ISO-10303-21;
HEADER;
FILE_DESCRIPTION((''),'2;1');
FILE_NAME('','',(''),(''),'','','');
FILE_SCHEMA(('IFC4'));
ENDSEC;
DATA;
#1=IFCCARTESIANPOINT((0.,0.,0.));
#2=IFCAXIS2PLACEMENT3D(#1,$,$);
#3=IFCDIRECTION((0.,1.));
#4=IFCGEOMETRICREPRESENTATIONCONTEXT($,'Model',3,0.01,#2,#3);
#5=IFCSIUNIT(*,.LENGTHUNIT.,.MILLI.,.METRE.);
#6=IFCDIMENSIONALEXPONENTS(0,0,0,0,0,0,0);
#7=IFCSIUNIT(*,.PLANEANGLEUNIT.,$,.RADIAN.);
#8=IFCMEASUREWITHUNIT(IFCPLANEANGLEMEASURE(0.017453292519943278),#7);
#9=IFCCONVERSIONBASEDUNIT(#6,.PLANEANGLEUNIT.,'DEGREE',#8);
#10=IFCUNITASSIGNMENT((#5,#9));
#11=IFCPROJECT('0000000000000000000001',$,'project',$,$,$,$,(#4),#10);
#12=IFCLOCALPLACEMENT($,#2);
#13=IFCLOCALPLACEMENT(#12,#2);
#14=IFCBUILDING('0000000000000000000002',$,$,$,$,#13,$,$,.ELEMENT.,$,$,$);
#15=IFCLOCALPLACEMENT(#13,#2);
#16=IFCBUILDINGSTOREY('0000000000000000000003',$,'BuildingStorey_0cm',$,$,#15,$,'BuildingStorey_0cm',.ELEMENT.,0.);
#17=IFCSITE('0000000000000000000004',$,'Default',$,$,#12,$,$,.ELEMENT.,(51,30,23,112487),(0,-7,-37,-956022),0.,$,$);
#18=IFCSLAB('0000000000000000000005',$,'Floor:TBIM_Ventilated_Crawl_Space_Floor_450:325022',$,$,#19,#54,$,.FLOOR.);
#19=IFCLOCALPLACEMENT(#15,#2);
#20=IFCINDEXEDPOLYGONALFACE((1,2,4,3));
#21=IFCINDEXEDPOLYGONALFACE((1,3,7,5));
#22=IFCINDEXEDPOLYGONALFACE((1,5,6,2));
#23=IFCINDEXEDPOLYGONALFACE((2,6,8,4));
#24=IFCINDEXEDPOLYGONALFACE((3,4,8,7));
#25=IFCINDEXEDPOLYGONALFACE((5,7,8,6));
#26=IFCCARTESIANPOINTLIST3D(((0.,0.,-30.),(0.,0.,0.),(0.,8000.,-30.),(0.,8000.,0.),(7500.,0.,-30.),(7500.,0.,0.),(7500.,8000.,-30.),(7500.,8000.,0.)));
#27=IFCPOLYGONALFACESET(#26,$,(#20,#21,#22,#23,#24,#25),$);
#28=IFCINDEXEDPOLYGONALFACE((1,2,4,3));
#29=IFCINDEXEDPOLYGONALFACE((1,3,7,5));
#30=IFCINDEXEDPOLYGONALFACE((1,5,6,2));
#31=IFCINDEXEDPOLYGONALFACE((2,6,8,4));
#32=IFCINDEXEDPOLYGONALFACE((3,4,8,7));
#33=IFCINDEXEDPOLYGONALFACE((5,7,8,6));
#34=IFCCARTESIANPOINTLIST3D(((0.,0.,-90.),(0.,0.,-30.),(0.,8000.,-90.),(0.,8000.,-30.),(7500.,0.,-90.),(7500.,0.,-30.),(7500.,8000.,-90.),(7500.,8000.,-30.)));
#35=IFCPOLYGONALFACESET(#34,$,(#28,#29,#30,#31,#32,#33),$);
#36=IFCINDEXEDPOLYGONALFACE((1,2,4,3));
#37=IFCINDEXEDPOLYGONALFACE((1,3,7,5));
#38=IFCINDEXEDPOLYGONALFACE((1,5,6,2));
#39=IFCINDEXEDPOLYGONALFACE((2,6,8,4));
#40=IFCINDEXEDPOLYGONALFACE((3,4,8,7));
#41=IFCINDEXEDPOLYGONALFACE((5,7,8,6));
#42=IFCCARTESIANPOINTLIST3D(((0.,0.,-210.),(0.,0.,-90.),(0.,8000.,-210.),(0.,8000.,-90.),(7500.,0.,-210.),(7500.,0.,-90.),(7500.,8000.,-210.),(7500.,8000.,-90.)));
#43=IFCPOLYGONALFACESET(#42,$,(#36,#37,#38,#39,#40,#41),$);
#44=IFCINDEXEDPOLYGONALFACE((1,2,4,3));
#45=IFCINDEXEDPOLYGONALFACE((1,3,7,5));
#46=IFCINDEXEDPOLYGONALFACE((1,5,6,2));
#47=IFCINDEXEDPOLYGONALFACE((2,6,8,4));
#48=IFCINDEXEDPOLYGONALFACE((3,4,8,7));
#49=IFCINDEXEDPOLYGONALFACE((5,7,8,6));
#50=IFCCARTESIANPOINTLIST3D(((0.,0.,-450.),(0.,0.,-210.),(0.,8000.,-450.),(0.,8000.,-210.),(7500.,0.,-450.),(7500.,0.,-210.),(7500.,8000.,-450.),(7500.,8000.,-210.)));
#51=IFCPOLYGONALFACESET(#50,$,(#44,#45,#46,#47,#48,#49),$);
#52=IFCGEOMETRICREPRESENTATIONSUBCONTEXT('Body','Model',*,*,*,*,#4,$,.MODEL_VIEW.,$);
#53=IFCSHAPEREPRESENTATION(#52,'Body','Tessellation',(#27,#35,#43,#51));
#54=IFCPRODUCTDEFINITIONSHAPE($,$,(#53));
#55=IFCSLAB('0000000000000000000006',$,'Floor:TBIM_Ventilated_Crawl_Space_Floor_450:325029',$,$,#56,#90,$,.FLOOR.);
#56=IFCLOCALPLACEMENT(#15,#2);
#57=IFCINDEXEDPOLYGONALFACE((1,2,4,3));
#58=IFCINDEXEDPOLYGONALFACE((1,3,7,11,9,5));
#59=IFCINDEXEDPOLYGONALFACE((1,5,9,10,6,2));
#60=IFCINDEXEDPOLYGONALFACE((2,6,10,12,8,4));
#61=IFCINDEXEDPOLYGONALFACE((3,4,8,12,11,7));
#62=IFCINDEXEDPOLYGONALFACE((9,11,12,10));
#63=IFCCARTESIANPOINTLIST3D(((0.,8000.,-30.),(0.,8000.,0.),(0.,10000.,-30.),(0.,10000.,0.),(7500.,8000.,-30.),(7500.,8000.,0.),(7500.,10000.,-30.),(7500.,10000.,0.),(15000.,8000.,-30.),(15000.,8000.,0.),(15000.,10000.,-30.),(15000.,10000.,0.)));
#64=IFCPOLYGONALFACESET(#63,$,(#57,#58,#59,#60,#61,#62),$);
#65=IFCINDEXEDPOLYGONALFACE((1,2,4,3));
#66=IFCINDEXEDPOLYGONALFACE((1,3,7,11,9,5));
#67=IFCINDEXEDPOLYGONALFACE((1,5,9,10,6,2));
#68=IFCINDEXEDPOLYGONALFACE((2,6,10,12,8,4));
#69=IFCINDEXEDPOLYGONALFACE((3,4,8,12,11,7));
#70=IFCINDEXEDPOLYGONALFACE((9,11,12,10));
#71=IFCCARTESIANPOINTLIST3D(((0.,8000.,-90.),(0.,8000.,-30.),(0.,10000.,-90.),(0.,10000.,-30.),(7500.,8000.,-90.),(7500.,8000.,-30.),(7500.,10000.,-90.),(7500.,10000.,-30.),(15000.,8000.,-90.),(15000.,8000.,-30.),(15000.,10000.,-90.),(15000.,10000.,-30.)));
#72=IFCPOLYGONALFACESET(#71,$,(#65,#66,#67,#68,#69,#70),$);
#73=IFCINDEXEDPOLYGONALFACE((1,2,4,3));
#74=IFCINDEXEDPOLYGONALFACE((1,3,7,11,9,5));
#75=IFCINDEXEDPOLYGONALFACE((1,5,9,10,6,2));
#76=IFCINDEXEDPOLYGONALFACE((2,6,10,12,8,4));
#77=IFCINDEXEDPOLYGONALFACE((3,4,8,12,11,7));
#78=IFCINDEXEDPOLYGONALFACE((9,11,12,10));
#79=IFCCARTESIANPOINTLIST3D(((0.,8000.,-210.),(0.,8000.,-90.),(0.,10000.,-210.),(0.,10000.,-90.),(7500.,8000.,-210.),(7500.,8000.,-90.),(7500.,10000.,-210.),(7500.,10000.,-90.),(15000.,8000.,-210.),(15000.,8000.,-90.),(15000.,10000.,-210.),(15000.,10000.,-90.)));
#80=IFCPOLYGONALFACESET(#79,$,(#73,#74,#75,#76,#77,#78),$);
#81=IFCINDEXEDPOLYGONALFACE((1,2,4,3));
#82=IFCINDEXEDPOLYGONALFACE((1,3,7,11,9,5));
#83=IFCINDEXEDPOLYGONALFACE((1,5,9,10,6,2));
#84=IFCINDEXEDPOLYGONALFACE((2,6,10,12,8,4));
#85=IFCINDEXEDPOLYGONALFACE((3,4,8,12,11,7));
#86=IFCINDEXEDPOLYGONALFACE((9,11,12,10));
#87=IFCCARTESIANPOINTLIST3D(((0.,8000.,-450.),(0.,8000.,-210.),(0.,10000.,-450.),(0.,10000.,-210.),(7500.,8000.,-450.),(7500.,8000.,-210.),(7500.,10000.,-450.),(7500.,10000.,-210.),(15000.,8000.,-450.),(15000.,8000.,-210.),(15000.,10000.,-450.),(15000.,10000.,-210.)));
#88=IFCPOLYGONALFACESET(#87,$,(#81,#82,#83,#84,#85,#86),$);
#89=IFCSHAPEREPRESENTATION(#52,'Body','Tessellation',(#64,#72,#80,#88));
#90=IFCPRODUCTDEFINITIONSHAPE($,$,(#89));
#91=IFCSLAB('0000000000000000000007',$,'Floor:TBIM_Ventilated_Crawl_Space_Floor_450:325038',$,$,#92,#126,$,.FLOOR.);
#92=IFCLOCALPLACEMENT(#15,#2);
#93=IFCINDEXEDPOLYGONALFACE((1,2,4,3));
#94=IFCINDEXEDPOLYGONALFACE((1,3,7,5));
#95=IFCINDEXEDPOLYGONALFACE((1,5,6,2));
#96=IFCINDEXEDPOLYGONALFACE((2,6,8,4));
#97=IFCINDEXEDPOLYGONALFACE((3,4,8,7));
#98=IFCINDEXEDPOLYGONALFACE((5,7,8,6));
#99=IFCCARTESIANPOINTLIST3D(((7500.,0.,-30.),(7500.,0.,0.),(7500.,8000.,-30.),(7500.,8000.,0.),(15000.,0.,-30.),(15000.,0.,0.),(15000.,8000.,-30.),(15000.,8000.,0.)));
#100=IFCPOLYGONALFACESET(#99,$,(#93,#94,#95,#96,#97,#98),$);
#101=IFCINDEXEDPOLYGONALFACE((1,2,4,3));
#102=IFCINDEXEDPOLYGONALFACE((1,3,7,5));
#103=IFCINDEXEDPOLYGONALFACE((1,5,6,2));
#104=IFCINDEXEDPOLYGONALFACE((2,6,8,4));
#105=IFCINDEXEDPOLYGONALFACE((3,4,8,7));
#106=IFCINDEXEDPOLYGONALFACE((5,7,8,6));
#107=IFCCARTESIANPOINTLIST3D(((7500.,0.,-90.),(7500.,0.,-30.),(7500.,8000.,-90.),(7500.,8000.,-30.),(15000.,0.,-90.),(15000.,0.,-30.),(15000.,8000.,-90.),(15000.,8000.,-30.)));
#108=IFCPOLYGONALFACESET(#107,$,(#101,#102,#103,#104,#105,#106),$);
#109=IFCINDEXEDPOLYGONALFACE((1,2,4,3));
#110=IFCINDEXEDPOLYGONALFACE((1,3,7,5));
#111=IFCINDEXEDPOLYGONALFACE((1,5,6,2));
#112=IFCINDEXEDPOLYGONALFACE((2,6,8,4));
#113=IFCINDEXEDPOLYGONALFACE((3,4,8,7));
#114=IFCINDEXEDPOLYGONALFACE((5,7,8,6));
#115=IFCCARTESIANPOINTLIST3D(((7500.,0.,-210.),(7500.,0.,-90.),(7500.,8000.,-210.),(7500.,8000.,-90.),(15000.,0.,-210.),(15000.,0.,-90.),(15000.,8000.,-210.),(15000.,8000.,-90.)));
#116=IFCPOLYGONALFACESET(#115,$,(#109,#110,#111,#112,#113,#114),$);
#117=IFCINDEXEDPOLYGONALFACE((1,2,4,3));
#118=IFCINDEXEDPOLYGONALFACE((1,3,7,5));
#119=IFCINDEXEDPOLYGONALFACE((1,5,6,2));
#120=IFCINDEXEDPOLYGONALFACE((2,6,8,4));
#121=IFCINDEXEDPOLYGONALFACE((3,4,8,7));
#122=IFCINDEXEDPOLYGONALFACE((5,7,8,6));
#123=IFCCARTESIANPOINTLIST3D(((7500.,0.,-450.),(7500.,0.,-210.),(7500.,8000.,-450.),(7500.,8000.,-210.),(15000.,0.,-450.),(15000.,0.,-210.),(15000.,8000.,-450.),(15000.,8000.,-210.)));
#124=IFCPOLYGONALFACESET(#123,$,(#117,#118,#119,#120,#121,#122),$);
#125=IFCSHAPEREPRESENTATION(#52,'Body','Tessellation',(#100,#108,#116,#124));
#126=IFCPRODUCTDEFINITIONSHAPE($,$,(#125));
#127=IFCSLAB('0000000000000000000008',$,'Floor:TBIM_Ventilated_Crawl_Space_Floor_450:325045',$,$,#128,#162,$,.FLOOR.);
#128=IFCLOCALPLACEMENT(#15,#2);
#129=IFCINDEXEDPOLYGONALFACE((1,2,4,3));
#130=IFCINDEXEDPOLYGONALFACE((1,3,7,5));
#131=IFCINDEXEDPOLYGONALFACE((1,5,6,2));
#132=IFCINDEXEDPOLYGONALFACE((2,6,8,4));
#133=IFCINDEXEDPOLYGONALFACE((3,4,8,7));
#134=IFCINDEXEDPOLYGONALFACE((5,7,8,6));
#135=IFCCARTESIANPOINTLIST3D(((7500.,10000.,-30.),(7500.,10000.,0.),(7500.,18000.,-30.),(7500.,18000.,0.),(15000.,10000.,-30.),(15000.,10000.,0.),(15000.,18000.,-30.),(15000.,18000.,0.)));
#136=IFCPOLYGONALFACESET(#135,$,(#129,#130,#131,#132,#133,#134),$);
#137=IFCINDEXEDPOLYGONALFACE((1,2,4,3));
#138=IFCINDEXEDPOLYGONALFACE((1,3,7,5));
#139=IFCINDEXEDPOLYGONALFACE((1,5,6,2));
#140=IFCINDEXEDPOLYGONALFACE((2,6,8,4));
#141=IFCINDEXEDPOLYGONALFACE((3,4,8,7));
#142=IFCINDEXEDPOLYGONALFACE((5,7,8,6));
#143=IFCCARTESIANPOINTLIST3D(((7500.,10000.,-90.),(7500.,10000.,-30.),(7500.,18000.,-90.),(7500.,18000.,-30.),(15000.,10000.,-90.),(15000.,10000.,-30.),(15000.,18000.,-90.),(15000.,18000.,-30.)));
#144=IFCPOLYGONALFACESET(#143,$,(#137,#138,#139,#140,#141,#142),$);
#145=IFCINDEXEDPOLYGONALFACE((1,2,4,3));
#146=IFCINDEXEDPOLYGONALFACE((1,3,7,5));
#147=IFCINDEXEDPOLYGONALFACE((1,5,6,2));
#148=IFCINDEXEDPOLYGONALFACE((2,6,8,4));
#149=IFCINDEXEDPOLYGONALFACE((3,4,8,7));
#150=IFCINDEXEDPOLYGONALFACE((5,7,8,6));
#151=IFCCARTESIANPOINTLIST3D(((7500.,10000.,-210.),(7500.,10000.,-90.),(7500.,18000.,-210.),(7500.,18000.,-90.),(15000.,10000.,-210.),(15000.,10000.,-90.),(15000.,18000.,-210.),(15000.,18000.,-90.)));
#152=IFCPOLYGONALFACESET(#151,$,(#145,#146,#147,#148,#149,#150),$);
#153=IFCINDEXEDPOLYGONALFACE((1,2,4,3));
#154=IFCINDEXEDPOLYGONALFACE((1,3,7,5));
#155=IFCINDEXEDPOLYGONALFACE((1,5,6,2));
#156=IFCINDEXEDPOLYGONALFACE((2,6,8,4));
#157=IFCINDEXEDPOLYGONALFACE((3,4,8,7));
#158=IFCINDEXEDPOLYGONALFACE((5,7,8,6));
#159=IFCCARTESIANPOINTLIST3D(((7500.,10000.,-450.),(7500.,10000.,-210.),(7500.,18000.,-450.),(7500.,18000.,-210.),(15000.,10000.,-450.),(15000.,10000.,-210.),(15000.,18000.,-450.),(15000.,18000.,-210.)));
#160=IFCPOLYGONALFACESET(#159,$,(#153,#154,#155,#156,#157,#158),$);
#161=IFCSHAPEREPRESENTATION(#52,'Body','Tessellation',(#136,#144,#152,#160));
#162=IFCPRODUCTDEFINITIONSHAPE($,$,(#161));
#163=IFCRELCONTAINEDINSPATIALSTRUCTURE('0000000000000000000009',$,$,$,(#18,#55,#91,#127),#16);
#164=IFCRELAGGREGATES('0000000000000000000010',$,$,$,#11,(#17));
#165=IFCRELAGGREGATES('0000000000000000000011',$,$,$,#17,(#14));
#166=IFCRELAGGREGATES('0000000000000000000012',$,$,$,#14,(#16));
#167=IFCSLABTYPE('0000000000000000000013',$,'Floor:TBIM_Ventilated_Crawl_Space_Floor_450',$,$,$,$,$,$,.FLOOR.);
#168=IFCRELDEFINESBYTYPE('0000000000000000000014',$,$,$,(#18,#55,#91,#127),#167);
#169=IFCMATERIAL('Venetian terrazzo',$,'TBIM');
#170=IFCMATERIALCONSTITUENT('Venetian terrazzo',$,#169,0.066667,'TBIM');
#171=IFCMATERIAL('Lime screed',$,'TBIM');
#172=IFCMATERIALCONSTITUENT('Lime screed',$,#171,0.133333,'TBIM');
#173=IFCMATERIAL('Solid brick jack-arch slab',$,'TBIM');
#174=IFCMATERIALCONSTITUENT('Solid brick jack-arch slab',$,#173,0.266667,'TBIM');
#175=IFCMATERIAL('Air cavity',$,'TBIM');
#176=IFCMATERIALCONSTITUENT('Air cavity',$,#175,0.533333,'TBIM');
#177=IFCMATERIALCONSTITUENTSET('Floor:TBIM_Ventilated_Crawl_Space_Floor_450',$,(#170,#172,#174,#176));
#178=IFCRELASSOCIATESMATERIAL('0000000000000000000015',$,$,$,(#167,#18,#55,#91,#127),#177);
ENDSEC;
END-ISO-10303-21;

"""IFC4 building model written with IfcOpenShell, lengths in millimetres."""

from ifc_helpers import new_model, entity, si_unit, converted_unit, direction, frame, origin, place, context, subcontext, project, spatial, indexed_curve, outline, extrude, material, constituent, constituent_set, type_object, element, save


model = new_model("IFC4")

# Units and contexts
model_context = context("Model", 3, precision=0.01, world=origin(), true_north=direction((0.0, 1.0)))
body_context = subcontext(model_context, "Body", "Model", "MODEL_VIEW")
ifc_project = project(units=[si_unit("LENGTHUNIT", "METRE", prefix="MILLI"), converted_unit("PLANEANGLEUNIT", "DEGREE", entity("IfcPlaneAngleMeasure", 0.017453292519943278), si_unit("PLANEANGLEUNIT", "RADIAN"), dimensions=[0, 0, 0, 0, 0, 0, 0])], contexts=[model_context])

# Site, building, storey
site_placement = place(None, origin())
site = spatial("IfcSite", under=ifc_project, at=site_placement, Name="Default", CompositionType="ELEMENT", RefLatitude=(51, 30, 23, 112487), RefLongitude=(0, -7, -37, -956022), RefElevation=0.0)
building_placement = place(site_placement, origin())
building = spatial("IfcBuilding", under=site, at=building_placement, CompositionType="ELEMENT")
storey_placement = place(building_placement, origin())
storey = spatial("IfcBuildingStorey", under=building, at=storey_placement, Name="BuildingStorey_0cm", LongName="BuildingStorey_0cm", CompositionType="ELEMENT", Elevation=0.0)

# Slabs
ifc_material_1 = material(Name="Venetian terrazzo", Category="TBIM")
ifc_constituent_1 = constituent(ifc_material_1, Name="Venetian terrazzo", Category="TBIM", fraction=0.066667)
ifc_material_2 = material(Name="Lime screed", Category="TBIM")
ifc_constituent_2 = constituent(ifc_material_2, Name="Lime screed", Category="TBIM", fraction=0.133333)
ifc_material_3 = material(Name="Solid brick jack-arch slab", Category="TBIM")
ifc_constituent_3 = constituent(ifc_material_3, Name="Solid brick jack-arch slab", Category="TBIM", fraction=0.266667)
ifc_material_4 = material(Name="Air cavity", Category="TBIM")
ifc_constituent_4 = constituent(ifc_material_4, Name="Air cavity", Category="TBIM", fraction=0.533333)
ifc_constituent_set_1 = constituent_set(constituents=[ifc_constituent_1, ifc_constituent_2, ifc_constituent_3, ifc_constituent_4], Name="Floor:TBIM_Ventilated_Crawl_Space_Floor_450")
slab_type = type_object("IfcSlabType", Name="Floor:TBIM_Ventilated_Crawl_Space_Floor_450", PredefinedType="FLOOR", material=ifc_constituent_set_1)
slab_1_placement = place(storey_placement, origin())
element("IfcSlab", 1, at=slab_1_placement, inside=storey, type_object=slab_type, material=ifc_constituent_set_1, Name="Floor:TBIM_Ventilated_Crawl_Space_Floor_450:325022", PredefinedType="FLOOR", context=body_context, shape_type="SweptSolid", body=[
    extrude(outline(indexed_curve([(-3750.0, -4000.0), (3750.0, -4000.0), (3750.0, 4000.0), (-3750.0, 4000.0), (-3750.0, -4000.0)], self_intersect=False)), frame((3750.0, 4000.0, -30.0), z_axis=(0.0, 0.0, 1.0), x_axis=(-1.0, 0.0, 0.0)), (0.0, 0.0, 1.0), 30.0),
    extrude(outline(indexed_curve([(-3750.0, -4000.0), (3750.0, -4000.0), (3750.0, 4000.0), (-3750.0, 4000.0), (-3750.0, -4000.0)], self_intersect=False)), frame((3750.0, 4000.0, -90.0), z_axis=(0.0, 0.0, 1.0), x_axis=(-1.0, 0.0, 0.0)), (0.0, 0.0, 1.0), 60.0),
    extrude(outline(indexed_curve([(-3750.0, -4000.0), (3750.0, -4000.0), (3750.0, 4000.0), (-3750.0, 4000.0), (-3750.0, -4000.0)], self_intersect=False)), frame((3750.0, 4000.0, -210.0), z_axis=(0.0, 0.0, 1.0), x_axis=(-1.0, 0.0, 0.0)), (0.0, 0.0, 1.0), 120.0),
    extrude(outline(indexed_curve([(-3750.0, -4000.0), (3750.0, -4000.0), (3750.0, 4000.0), (-3750.0, 4000.0), (-3750.0, -4000.0)], self_intersect=False)), frame((3750.0, 4000.0, -450.0), z_axis=(0.0, 0.0, 1.0), x_axis=(-1.0, 0.0, 0.0)), (0.0, 0.0, 1.0), 240.0),
])
slab_2_placement = place(storey_placement, origin())
element("IfcSlab", 2, at=slab_2_placement, inside=storey, type_object=slab_type, material=ifc_constituent_set_1, Name="Floor:TBIM_Ventilated_Crawl_Space_Floor_450:325029", PredefinedType="FLOOR", context=body_context, shape_type="SweptSolid", body=[
    extrude(outline(indexed_curve([(-7500.0, -1000.0), (0.0, -1000.0), (7500.0, -1000.0), (7500.0, 1000.0), (0.0, 1000.0), (-7500.0, 1000.0), (-7500.0, -1000.0)], self_intersect=False)), frame((7500.0, 9000.0, -30.0), z_axis=(0.0, 0.0, 1.0), x_axis=(-1.0, 0.0, 0.0)), (0.0, 0.0, 1.0), 30.0),
    extrude(outline(indexed_curve([(-7500.0, -1000.0), (0.0, -1000.0), (7500.0, -1000.0), (7500.0, 1000.0), (0.0, 1000.0), (-7500.0, 1000.0), (-7500.0, -1000.0)], self_intersect=False)), frame((7500.0, 9000.0, -90.0), z_axis=(0.0, 0.0, 1.0), x_axis=(-1.0, 0.0, 0.0)), (0.0, 0.0, 1.0), 60.0),
    extrude(outline(indexed_curve([(-7500.0, -1000.0), (0.0, -1000.0), (7500.0, -1000.0), (7500.0, 1000.0), (0.0, 1000.0), (-7500.0, 1000.0), (-7500.0, -1000.0)], self_intersect=False)), frame((7500.0, 9000.0, -210.0), z_axis=(0.0, 0.0, 1.0), x_axis=(-1.0, 0.0, 0.0)), (0.0, 0.0, 1.0), 120.0),
    extrude(outline(indexed_curve([(-7500.0, -1000.0), (0.0, -1000.0), (7500.0, -1000.0), (7500.0, 1000.0), (0.0, 1000.0), (-7500.0, 1000.0), (-7500.0, -1000.0)], self_intersect=False)), frame((7500.0, 9000.0, -450.0), z_axis=(0.0, 0.0, 1.0), x_axis=(-1.0, 0.0, 0.0)), (0.0, 0.0, 1.0), 240.0),
])
slab_3_placement = place(storey_placement, origin())
element("IfcSlab", 3, at=slab_3_placement, inside=storey, type_object=slab_type, material=ifc_constituent_set_1, Name="Floor:TBIM_Ventilated_Crawl_Space_Floor_450:325038", PredefinedType="FLOOR", context=body_context, shape_type="SweptSolid", body=[
    extrude(outline(indexed_curve([(-3750.0, -4000.0), (3750.0, -4000.0), (3750.0, 4000.0), (-3750.0, 4000.0), (-3750.0, -4000.0)], self_intersect=False)), frame((11250.0, 4000.0, -30.0), z_axis=(0.0, 0.0, 1.0), x_axis=(-1.0, 0.0, 0.0)), (0.0, 0.0, 1.0), 30.0),
    extrude(outline(indexed_curve([(-3750.0, -4000.0), (3750.0, -4000.0), (3750.0, 4000.0), (-3750.0, 4000.0), (-3750.0, -4000.0)], self_intersect=False)), frame((11250.0, 4000.0, -90.0), z_axis=(0.0, 0.0, 1.0), x_axis=(-1.0, 0.0, 0.0)), (0.0, 0.0, 1.0), 60.0),
    extrude(outline(indexed_curve([(-3750.0, -4000.0), (3750.0, -4000.0), (3750.0, 4000.0), (-3750.0, 4000.0), (-3750.0, -4000.0)], self_intersect=False)), frame((11250.0, 4000.0, -210.0), z_axis=(0.0, 0.0, 1.0), x_axis=(-1.0, 0.0, 0.0)), (0.0, 0.0, 1.0), 120.0),
    extrude(outline(indexed_curve([(-3750.0, -4000.0), (3750.0, -4000.0), (3750.0, 4000.0), (-3750.0, 4000.0), (-3750.0, -4000.0)], self_intersect=False)), frame((11250.0, 4000.0, -450.0), z_axis=(0.0, 0.0, 1.0), x_axis=(-1.0, 0.0, 0.0)), (0.0, 0.0, 1.0), 240.0),
])
slab_4_placement = place(storey_placement, origin())
element("IfcSlab", 4, at=slab_4_placement, inside=storey, type_object=slab_type, material=ifc_constituent_set_1, Name="Floor:TBIM_Ventilated_Crawl_Space_Floor_450:325045", PredefinedType="FLOOR", context=body_context, shape_type="SweptSolid", body=[
    extrude(outline(indexed_curve([(-3750.0, -4000.0), (3750.0, -4000.0), (3750.0, 4000.0), (-3750.0, 4000.0), (-3750.0, -4000.0)], self_intersect=False)), frame((11250.0, 14000.0, -30.0), z_axis=(0.0, 0.0, 1.0), x_axis=(-1.0, 0.0, 0.0)), (0.0, 0.0, 1.0), 30.0),
    extrude(outline(indexed_curve([(-3750.0, -4000.0), (3750.0, -4000.0), (3750.0, 4000.0), (-3750.0, 4000.0), (-3750.0, -4000.0)], self_intersect=False)), frame((11250.0, 14000.0, -90.0), z_axis=(0.0, 0.0, 1.0), x_axis=(-1.0, 0.0, 0.0)), (0.0, 0.0, 1.0), 60.0),
    extrude(outline(indexed_curve([(-3750.0, -4000.0), (3750.0, -4000.0), (3750.0, 4000.0), (-3750.0, 4000.0), (-3750.0, -4000.0)], self_intersect=False)), frame((11250.0, 14000.0, -210.0), z_axis=(0.0, 0.0, 1.0), x_axis=(-1.0, 0.0, 0.0)), (0.0, 0.0, 1.0), 120.0),
    extrude(outline(indexed_curve([(-3750.0, -4000.0), (3750.0, -4000.0), (3750.0, 4000.0), (-3750.0, 4000.0), (-3750.0, -4000.0)], self_intersect=False)), frame((11250.0, 14000.0, -450.0), z_axis=(0.0, 0.0, 1.0), x_axis=(-1.0, 0.0, 0.0)), (0.0, 0.0, 1.0), 240.0),
])

save(model, "model.ifc")
